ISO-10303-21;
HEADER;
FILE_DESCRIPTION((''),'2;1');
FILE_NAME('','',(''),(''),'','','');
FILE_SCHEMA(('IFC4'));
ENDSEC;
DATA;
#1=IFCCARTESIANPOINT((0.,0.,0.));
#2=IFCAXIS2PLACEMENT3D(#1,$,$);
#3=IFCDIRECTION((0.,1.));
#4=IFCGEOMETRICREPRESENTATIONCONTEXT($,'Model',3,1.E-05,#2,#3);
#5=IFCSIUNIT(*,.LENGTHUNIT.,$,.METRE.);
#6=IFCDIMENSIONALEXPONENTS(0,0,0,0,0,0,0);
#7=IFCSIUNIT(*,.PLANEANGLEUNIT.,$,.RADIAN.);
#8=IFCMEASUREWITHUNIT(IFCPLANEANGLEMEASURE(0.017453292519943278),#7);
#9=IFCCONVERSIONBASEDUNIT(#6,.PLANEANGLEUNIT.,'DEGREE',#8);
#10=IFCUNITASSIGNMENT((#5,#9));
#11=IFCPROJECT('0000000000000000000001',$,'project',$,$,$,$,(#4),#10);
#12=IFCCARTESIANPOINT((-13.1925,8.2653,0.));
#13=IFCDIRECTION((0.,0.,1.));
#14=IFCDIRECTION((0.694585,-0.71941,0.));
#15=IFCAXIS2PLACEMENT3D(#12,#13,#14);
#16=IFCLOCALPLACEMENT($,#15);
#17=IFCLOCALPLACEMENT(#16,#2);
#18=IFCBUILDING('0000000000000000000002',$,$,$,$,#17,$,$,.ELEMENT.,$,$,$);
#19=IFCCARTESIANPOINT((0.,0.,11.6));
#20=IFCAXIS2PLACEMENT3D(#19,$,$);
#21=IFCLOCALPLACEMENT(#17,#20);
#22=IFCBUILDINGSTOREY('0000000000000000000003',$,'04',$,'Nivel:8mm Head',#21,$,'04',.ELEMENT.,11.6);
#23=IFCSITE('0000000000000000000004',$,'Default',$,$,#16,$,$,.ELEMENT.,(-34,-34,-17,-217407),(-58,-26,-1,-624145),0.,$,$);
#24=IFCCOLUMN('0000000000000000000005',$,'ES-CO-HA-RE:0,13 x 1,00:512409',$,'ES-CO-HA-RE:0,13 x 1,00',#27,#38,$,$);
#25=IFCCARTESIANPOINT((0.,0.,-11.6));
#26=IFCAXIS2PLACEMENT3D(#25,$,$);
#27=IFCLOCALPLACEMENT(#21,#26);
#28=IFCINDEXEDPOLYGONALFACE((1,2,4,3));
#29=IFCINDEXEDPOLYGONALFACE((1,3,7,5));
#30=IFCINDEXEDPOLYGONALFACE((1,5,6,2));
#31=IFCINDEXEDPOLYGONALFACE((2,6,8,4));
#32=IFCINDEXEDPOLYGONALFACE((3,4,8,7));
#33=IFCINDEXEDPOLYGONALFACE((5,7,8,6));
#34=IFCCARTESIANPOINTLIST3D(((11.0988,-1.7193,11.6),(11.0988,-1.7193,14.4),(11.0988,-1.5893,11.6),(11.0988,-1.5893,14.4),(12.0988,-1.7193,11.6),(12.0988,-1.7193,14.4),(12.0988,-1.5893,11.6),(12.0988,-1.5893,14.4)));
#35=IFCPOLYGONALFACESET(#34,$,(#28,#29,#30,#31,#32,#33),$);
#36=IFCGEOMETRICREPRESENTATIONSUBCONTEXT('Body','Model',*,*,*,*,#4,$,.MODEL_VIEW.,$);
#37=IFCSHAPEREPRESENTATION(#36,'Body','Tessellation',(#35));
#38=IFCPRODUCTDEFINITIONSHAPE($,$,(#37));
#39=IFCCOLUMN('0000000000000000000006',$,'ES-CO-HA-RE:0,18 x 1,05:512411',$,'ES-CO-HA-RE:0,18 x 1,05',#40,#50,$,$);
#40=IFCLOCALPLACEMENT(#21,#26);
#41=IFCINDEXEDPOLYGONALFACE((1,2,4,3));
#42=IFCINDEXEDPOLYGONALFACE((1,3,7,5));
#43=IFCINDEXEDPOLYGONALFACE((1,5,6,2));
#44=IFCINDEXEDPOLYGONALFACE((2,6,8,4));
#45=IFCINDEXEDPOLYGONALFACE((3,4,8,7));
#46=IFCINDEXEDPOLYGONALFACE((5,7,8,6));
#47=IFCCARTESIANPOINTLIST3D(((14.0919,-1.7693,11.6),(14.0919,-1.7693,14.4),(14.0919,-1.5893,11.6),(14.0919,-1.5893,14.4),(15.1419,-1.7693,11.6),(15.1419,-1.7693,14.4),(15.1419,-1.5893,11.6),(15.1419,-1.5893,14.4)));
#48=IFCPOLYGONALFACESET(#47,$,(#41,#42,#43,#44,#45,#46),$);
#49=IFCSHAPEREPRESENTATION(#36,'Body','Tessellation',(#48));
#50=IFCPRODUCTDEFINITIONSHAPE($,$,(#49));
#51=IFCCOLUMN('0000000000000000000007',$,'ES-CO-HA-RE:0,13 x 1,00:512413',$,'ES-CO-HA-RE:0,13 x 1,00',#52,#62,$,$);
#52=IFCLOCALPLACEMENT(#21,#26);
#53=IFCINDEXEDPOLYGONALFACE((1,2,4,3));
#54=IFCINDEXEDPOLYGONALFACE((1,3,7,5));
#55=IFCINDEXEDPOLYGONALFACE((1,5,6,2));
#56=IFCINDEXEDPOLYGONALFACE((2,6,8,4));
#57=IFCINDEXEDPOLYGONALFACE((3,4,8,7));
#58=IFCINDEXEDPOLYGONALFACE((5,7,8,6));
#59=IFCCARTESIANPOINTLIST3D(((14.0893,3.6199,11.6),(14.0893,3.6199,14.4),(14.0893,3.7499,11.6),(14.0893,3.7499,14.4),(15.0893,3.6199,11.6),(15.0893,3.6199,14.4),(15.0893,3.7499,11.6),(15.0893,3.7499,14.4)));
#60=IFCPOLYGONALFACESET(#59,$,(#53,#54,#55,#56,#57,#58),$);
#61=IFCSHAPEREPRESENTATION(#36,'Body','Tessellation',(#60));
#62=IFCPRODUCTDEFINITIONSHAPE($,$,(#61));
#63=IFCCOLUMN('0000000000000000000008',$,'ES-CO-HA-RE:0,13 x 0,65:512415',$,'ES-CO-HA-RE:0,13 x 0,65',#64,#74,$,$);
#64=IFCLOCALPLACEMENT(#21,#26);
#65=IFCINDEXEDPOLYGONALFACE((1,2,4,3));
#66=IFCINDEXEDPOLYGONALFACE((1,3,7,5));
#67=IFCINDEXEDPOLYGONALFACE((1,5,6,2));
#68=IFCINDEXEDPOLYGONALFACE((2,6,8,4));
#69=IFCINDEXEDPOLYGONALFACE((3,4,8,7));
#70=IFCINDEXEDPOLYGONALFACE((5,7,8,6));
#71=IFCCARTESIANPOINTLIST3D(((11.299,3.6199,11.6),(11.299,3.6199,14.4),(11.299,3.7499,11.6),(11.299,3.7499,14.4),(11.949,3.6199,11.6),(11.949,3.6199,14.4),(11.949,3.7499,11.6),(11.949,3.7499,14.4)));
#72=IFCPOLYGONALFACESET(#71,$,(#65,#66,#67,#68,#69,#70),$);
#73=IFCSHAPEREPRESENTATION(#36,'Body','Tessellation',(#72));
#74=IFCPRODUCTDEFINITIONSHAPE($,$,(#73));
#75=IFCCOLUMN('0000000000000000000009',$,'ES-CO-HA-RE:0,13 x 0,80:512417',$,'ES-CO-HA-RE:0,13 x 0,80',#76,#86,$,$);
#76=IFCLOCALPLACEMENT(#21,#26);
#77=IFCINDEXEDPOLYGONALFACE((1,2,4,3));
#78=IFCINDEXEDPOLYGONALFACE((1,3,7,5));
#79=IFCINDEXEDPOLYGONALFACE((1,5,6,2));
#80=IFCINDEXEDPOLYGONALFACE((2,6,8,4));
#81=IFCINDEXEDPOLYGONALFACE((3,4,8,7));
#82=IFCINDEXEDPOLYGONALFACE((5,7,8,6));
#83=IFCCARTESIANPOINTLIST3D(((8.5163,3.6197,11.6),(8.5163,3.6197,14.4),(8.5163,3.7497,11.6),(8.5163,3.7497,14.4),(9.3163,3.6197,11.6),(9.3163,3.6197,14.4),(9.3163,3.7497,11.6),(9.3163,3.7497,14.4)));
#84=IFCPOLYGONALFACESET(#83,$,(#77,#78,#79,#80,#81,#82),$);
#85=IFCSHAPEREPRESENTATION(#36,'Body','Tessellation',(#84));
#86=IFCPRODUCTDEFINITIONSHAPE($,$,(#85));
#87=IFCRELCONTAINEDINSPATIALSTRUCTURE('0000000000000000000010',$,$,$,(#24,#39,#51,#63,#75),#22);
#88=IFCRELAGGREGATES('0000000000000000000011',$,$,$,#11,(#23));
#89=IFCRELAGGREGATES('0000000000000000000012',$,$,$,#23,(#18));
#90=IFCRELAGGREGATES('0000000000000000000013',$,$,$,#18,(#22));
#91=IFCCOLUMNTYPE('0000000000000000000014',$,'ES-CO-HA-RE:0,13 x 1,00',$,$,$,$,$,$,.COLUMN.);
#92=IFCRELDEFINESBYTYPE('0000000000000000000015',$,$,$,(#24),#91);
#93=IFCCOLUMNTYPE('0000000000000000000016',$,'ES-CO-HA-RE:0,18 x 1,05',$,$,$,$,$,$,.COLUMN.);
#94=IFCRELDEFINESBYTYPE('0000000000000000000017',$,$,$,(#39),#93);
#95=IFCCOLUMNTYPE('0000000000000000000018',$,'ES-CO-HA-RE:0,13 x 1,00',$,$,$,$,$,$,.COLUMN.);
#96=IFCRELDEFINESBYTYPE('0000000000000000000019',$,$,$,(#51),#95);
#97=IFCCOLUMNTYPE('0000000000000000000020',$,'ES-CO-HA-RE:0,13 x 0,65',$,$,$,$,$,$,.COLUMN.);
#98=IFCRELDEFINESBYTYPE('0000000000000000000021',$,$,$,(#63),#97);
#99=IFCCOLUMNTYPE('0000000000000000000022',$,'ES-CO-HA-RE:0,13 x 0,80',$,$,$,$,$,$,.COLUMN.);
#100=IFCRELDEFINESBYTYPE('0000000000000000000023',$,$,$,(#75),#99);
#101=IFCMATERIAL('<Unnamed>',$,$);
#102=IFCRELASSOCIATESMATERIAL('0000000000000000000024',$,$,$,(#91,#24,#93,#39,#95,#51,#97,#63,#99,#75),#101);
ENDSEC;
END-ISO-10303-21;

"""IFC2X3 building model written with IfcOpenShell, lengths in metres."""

from ifc_helpers import new_model, entity, si_unit, converted_unit, direction, frame, frame_2d, origin, origin_2d_with_axis, place, context, subcontext, project, spatial, rectangle, extrude, source, transform, mapped, material, type_object, type_shapes, element, save


model = new_model("IFC2X3")

# Units and contexts
model_context = context("Model", 3, precision=1e-05, world=origin(), true_north=direction((0.0, 1.0)))
body_context = subcontext(model_context, "Body", "Model", "MODEL_VIEW")
ifc_project = project(units=[si_unit("LENGTHUNIT", "METRE"), converted_unit("PLANEANGLEUNIT", "DEGREE", entity("IfcPlaneAngleMeasure", 0.017453292519943278), si_unit("PLANEANGLEUNIT", "RADIAN"), dimensions=[0, 0, 0, 0, 0, 0, 0])], contexts=[model_context])

# Site, building, storey
site_placement = place(None, frame((-13.1925, 8.2653, 0.0), z_axis=(0.0, 0.0, 1.0), x_axis=(0.694585, -0.71941, 0.0)))
site = spatial("IfcSite", under=ifc_project, at=site_placement, Name="Default", CompositionType="ELEMENT", RefLatitude=(-34, -34, -17, -217407), RefLongitude=(-58, -26, -1, -624145), RefElevation=0.0)
building_placement = place(site_placement, origin())
building = spatial("IfcBuilding", under=site, at=building_placement, CompositionType="ELEMENT")
storey_placement = place(building_placement, frame((0.0, 0.0, 11.6)))
storey = spatial("IfcBuildingStorey", under=building, at=storey_placement, Name="04", ObjectType="Nivel:8mm Head", LongName="04", CompositionType="ELEMENT", Elevation=11.6)

# Columns
ifc_material_1 = material(Name="<Unnamed>")
column_type_1 = type_object("IfcColumnType", Name="ES-CO-HA-RE:0,13 x 1,00", PredefinedType="COLUMN", material=ifc_material_1)
shared_shape_1 = source(origin(), body_context, "Body", "SweptSolid", [
    extrude(rectangle(XDim=1.0, YDim=0.13, at=frame_2d((0.0, 0.0), x_axis=(1.0, 0.0))), frame((11.5988, -1.6543, 11.6), z_axis=(0.0, 0.0, 1.0), x_axis=(-1.0, 0.0, 0.0)), (0.0, 0.0, 1.0), 2.8),
])
type_shapes(column_type_1, [shared_shape_1])
column_1_placement = place(storey_placement, frame((0.0, 0.0, -11.6)))
element("IfcColumn", 1, at=column_1_placement, inside=storey, type_object=column_type_1, material=ifc_material_1, Name="ES-CO-HA-RE:0,13 x 1,00:512409", ObjectType="ES-CO-HA-RE:0,13 x 1,00", context=body_context, shape_type="MappedRepresentation", body=[
    mapped(shared_shape_1, transform((0.0, 0.0, 0.0), scale=1.0)),
])
column_type_2 = type_object("IfcColumnType", Name="ES-CO-HA-RE:0,18 x 1,05", PredefinedType="COLUMN", material=ifc_material_1)
shared_shape_2 = source(origin(), body_context, "Body", "SweptSolid", [
    extrude(rectangle(XDim=1.05, YDim=0.18, at=frame_2d((0.0, 0.0), x_axis=(1.0, 0.0))), frame((14.6169, -1.6793, 11.6), z_axis=(0.0, 0.0, 1.0), x_axis=(-1.0, 0.0, 0.0)), (0.0, 0.0, 1.0), 2.8),
])
type_shapes(column_type_2, [shared_shape_2])
column_2_placement = place(storey_placement, frame((0.0, 0.0, -11.6)))
element("IfcColumn", 2, at=column_2_placement, inside=storey, type_object=column_type_2, material=ifc_material_1, Name="ES-CO-HA-RE:0,18 x 1,05:512411", ObjectType="ES-CO-HA-RE:0,18 x 1,05", context=body_context, shape_type="MappedRepresentation", body=[
    mapped(shared_shape_2, transform((0.0, 0.0, 0.0), scale=1.0)),
])
column_type_3 = type_object("IfcColumnType", Name="ES-CO-HA-RE:0,13 x 1,00", PredefinedType="COLUMN", material=ifc_material_1)
shared_shape_3 = source(origin(), body_context, "Body", "SweptSolid", [
    extrude(rectangle(XDim=1.0, YDim=0.13, at=frame_2d((0.0, 0.0), x_axis=(1.0, 0.0))), frame((14.5893, 3.6849, 11.6), z_axis=(0.0, 0.0, 1.0), x_axis=(-1.0, 0.0, 0.0)), (0.0, 0.0, 1.0), 2.8),
])
type_shapes(column_type_3, [shared_shape_3])
column_3_placement = place(storey_placement, frame((0.0, 0.0, -11.6)))
element("IfcColumn", 3, at=column_3_placement, inside=storey, type_object=column_type_3, material=ifc_material_1, Name="ES-CO-HA-RE:0,13 x 1,00:512413", ObjectType="ES-CO-HA-RE:0,13 x 1,00", context=body_context, shape_type="MappedRepresentation", body=[
    mapped(shared_shape_3, transform((0.0, 0.0, 0.0), scale=1.0)),
])
column_type_4 = type_object("IfcColumnType", Name="ES-CO-HA-RE:0,13 x 0,65", PredefinedType="COLUMN", material=ifc_material_1)
shared_shape_4 = source(origin(), body_context, "Body", "SweptSolid", [
    extrude(rectangle(XDim=0.65, YDim=0.13, at=frame_2d((0.0, 0.0), x_axis=(1.0, 0.0))), frame((11.624, 3.6849, 11.6), z_axis=(0.0, 0.0, 1.0), x_axis=(-1.0, 0.0, 0.0)), (0.0, 0.0, 1.0), 2.8),
])
type_shapes(column_type_4, [shared_shape_4])
column_4_placement = place(storey_placement, frame((0.0, 0.0, -11.6)))
element("IfcColumn", 4, at=column_4_placement, inside=storey, type_object=column_type_4, material=ifc_material_1, Name="ES-CO-HA-RE:0,13 x 0,65:512415", ObjectType="ES-CO-HA-RE:0,13 x 0,65", context=body_context, shape_type="MappedRepresentation", body=[
    mapped(shared_shape_4, transform((0.0, 0.0, 0.0), scale=1.0)),
])
column_type_5 = type_object("IfcColumnType", Name="ES-CO-HA-RE:0,13 x 0,80", PredefinedType="COLUMN", material=ifc_material_1)
shared_shape_5 = source(origin(), body_context, "Body", "SweptSolid", [
    extrude(rectangle(XDim=0.8, YDim=0.13, at=origin_2d_with_axis()), frame((8.9163, 3.6847, 11.6), z_axis=(0.0, 0.0, 1.0), x_axis=(-1.0, 0.0, 0.0)), (0.0, 0.0, 1.0), 2.8),
])
type_shapes(column_type_5, [shared_shape_5])
column_5_placement = place(storey_placement, frame((0.0, 0.0, -11.6)))
element("IfcColumn", 5, at=column_5_placement, inside=storey, type_object=column_type_5, material=ifc_material_1, Name="ES-CO-HA-RE:0,13 x 0,80:512417", ObjectType="ES-CO-HA-RE:0,13 x 0,80", context=body_context, shape_type="MappedRepresentation", body=[
    mapped(shared_shape_5, transform((0.0, 0.0, 0.0), scale=1.0)),
])

save(model, "model.ifc")
